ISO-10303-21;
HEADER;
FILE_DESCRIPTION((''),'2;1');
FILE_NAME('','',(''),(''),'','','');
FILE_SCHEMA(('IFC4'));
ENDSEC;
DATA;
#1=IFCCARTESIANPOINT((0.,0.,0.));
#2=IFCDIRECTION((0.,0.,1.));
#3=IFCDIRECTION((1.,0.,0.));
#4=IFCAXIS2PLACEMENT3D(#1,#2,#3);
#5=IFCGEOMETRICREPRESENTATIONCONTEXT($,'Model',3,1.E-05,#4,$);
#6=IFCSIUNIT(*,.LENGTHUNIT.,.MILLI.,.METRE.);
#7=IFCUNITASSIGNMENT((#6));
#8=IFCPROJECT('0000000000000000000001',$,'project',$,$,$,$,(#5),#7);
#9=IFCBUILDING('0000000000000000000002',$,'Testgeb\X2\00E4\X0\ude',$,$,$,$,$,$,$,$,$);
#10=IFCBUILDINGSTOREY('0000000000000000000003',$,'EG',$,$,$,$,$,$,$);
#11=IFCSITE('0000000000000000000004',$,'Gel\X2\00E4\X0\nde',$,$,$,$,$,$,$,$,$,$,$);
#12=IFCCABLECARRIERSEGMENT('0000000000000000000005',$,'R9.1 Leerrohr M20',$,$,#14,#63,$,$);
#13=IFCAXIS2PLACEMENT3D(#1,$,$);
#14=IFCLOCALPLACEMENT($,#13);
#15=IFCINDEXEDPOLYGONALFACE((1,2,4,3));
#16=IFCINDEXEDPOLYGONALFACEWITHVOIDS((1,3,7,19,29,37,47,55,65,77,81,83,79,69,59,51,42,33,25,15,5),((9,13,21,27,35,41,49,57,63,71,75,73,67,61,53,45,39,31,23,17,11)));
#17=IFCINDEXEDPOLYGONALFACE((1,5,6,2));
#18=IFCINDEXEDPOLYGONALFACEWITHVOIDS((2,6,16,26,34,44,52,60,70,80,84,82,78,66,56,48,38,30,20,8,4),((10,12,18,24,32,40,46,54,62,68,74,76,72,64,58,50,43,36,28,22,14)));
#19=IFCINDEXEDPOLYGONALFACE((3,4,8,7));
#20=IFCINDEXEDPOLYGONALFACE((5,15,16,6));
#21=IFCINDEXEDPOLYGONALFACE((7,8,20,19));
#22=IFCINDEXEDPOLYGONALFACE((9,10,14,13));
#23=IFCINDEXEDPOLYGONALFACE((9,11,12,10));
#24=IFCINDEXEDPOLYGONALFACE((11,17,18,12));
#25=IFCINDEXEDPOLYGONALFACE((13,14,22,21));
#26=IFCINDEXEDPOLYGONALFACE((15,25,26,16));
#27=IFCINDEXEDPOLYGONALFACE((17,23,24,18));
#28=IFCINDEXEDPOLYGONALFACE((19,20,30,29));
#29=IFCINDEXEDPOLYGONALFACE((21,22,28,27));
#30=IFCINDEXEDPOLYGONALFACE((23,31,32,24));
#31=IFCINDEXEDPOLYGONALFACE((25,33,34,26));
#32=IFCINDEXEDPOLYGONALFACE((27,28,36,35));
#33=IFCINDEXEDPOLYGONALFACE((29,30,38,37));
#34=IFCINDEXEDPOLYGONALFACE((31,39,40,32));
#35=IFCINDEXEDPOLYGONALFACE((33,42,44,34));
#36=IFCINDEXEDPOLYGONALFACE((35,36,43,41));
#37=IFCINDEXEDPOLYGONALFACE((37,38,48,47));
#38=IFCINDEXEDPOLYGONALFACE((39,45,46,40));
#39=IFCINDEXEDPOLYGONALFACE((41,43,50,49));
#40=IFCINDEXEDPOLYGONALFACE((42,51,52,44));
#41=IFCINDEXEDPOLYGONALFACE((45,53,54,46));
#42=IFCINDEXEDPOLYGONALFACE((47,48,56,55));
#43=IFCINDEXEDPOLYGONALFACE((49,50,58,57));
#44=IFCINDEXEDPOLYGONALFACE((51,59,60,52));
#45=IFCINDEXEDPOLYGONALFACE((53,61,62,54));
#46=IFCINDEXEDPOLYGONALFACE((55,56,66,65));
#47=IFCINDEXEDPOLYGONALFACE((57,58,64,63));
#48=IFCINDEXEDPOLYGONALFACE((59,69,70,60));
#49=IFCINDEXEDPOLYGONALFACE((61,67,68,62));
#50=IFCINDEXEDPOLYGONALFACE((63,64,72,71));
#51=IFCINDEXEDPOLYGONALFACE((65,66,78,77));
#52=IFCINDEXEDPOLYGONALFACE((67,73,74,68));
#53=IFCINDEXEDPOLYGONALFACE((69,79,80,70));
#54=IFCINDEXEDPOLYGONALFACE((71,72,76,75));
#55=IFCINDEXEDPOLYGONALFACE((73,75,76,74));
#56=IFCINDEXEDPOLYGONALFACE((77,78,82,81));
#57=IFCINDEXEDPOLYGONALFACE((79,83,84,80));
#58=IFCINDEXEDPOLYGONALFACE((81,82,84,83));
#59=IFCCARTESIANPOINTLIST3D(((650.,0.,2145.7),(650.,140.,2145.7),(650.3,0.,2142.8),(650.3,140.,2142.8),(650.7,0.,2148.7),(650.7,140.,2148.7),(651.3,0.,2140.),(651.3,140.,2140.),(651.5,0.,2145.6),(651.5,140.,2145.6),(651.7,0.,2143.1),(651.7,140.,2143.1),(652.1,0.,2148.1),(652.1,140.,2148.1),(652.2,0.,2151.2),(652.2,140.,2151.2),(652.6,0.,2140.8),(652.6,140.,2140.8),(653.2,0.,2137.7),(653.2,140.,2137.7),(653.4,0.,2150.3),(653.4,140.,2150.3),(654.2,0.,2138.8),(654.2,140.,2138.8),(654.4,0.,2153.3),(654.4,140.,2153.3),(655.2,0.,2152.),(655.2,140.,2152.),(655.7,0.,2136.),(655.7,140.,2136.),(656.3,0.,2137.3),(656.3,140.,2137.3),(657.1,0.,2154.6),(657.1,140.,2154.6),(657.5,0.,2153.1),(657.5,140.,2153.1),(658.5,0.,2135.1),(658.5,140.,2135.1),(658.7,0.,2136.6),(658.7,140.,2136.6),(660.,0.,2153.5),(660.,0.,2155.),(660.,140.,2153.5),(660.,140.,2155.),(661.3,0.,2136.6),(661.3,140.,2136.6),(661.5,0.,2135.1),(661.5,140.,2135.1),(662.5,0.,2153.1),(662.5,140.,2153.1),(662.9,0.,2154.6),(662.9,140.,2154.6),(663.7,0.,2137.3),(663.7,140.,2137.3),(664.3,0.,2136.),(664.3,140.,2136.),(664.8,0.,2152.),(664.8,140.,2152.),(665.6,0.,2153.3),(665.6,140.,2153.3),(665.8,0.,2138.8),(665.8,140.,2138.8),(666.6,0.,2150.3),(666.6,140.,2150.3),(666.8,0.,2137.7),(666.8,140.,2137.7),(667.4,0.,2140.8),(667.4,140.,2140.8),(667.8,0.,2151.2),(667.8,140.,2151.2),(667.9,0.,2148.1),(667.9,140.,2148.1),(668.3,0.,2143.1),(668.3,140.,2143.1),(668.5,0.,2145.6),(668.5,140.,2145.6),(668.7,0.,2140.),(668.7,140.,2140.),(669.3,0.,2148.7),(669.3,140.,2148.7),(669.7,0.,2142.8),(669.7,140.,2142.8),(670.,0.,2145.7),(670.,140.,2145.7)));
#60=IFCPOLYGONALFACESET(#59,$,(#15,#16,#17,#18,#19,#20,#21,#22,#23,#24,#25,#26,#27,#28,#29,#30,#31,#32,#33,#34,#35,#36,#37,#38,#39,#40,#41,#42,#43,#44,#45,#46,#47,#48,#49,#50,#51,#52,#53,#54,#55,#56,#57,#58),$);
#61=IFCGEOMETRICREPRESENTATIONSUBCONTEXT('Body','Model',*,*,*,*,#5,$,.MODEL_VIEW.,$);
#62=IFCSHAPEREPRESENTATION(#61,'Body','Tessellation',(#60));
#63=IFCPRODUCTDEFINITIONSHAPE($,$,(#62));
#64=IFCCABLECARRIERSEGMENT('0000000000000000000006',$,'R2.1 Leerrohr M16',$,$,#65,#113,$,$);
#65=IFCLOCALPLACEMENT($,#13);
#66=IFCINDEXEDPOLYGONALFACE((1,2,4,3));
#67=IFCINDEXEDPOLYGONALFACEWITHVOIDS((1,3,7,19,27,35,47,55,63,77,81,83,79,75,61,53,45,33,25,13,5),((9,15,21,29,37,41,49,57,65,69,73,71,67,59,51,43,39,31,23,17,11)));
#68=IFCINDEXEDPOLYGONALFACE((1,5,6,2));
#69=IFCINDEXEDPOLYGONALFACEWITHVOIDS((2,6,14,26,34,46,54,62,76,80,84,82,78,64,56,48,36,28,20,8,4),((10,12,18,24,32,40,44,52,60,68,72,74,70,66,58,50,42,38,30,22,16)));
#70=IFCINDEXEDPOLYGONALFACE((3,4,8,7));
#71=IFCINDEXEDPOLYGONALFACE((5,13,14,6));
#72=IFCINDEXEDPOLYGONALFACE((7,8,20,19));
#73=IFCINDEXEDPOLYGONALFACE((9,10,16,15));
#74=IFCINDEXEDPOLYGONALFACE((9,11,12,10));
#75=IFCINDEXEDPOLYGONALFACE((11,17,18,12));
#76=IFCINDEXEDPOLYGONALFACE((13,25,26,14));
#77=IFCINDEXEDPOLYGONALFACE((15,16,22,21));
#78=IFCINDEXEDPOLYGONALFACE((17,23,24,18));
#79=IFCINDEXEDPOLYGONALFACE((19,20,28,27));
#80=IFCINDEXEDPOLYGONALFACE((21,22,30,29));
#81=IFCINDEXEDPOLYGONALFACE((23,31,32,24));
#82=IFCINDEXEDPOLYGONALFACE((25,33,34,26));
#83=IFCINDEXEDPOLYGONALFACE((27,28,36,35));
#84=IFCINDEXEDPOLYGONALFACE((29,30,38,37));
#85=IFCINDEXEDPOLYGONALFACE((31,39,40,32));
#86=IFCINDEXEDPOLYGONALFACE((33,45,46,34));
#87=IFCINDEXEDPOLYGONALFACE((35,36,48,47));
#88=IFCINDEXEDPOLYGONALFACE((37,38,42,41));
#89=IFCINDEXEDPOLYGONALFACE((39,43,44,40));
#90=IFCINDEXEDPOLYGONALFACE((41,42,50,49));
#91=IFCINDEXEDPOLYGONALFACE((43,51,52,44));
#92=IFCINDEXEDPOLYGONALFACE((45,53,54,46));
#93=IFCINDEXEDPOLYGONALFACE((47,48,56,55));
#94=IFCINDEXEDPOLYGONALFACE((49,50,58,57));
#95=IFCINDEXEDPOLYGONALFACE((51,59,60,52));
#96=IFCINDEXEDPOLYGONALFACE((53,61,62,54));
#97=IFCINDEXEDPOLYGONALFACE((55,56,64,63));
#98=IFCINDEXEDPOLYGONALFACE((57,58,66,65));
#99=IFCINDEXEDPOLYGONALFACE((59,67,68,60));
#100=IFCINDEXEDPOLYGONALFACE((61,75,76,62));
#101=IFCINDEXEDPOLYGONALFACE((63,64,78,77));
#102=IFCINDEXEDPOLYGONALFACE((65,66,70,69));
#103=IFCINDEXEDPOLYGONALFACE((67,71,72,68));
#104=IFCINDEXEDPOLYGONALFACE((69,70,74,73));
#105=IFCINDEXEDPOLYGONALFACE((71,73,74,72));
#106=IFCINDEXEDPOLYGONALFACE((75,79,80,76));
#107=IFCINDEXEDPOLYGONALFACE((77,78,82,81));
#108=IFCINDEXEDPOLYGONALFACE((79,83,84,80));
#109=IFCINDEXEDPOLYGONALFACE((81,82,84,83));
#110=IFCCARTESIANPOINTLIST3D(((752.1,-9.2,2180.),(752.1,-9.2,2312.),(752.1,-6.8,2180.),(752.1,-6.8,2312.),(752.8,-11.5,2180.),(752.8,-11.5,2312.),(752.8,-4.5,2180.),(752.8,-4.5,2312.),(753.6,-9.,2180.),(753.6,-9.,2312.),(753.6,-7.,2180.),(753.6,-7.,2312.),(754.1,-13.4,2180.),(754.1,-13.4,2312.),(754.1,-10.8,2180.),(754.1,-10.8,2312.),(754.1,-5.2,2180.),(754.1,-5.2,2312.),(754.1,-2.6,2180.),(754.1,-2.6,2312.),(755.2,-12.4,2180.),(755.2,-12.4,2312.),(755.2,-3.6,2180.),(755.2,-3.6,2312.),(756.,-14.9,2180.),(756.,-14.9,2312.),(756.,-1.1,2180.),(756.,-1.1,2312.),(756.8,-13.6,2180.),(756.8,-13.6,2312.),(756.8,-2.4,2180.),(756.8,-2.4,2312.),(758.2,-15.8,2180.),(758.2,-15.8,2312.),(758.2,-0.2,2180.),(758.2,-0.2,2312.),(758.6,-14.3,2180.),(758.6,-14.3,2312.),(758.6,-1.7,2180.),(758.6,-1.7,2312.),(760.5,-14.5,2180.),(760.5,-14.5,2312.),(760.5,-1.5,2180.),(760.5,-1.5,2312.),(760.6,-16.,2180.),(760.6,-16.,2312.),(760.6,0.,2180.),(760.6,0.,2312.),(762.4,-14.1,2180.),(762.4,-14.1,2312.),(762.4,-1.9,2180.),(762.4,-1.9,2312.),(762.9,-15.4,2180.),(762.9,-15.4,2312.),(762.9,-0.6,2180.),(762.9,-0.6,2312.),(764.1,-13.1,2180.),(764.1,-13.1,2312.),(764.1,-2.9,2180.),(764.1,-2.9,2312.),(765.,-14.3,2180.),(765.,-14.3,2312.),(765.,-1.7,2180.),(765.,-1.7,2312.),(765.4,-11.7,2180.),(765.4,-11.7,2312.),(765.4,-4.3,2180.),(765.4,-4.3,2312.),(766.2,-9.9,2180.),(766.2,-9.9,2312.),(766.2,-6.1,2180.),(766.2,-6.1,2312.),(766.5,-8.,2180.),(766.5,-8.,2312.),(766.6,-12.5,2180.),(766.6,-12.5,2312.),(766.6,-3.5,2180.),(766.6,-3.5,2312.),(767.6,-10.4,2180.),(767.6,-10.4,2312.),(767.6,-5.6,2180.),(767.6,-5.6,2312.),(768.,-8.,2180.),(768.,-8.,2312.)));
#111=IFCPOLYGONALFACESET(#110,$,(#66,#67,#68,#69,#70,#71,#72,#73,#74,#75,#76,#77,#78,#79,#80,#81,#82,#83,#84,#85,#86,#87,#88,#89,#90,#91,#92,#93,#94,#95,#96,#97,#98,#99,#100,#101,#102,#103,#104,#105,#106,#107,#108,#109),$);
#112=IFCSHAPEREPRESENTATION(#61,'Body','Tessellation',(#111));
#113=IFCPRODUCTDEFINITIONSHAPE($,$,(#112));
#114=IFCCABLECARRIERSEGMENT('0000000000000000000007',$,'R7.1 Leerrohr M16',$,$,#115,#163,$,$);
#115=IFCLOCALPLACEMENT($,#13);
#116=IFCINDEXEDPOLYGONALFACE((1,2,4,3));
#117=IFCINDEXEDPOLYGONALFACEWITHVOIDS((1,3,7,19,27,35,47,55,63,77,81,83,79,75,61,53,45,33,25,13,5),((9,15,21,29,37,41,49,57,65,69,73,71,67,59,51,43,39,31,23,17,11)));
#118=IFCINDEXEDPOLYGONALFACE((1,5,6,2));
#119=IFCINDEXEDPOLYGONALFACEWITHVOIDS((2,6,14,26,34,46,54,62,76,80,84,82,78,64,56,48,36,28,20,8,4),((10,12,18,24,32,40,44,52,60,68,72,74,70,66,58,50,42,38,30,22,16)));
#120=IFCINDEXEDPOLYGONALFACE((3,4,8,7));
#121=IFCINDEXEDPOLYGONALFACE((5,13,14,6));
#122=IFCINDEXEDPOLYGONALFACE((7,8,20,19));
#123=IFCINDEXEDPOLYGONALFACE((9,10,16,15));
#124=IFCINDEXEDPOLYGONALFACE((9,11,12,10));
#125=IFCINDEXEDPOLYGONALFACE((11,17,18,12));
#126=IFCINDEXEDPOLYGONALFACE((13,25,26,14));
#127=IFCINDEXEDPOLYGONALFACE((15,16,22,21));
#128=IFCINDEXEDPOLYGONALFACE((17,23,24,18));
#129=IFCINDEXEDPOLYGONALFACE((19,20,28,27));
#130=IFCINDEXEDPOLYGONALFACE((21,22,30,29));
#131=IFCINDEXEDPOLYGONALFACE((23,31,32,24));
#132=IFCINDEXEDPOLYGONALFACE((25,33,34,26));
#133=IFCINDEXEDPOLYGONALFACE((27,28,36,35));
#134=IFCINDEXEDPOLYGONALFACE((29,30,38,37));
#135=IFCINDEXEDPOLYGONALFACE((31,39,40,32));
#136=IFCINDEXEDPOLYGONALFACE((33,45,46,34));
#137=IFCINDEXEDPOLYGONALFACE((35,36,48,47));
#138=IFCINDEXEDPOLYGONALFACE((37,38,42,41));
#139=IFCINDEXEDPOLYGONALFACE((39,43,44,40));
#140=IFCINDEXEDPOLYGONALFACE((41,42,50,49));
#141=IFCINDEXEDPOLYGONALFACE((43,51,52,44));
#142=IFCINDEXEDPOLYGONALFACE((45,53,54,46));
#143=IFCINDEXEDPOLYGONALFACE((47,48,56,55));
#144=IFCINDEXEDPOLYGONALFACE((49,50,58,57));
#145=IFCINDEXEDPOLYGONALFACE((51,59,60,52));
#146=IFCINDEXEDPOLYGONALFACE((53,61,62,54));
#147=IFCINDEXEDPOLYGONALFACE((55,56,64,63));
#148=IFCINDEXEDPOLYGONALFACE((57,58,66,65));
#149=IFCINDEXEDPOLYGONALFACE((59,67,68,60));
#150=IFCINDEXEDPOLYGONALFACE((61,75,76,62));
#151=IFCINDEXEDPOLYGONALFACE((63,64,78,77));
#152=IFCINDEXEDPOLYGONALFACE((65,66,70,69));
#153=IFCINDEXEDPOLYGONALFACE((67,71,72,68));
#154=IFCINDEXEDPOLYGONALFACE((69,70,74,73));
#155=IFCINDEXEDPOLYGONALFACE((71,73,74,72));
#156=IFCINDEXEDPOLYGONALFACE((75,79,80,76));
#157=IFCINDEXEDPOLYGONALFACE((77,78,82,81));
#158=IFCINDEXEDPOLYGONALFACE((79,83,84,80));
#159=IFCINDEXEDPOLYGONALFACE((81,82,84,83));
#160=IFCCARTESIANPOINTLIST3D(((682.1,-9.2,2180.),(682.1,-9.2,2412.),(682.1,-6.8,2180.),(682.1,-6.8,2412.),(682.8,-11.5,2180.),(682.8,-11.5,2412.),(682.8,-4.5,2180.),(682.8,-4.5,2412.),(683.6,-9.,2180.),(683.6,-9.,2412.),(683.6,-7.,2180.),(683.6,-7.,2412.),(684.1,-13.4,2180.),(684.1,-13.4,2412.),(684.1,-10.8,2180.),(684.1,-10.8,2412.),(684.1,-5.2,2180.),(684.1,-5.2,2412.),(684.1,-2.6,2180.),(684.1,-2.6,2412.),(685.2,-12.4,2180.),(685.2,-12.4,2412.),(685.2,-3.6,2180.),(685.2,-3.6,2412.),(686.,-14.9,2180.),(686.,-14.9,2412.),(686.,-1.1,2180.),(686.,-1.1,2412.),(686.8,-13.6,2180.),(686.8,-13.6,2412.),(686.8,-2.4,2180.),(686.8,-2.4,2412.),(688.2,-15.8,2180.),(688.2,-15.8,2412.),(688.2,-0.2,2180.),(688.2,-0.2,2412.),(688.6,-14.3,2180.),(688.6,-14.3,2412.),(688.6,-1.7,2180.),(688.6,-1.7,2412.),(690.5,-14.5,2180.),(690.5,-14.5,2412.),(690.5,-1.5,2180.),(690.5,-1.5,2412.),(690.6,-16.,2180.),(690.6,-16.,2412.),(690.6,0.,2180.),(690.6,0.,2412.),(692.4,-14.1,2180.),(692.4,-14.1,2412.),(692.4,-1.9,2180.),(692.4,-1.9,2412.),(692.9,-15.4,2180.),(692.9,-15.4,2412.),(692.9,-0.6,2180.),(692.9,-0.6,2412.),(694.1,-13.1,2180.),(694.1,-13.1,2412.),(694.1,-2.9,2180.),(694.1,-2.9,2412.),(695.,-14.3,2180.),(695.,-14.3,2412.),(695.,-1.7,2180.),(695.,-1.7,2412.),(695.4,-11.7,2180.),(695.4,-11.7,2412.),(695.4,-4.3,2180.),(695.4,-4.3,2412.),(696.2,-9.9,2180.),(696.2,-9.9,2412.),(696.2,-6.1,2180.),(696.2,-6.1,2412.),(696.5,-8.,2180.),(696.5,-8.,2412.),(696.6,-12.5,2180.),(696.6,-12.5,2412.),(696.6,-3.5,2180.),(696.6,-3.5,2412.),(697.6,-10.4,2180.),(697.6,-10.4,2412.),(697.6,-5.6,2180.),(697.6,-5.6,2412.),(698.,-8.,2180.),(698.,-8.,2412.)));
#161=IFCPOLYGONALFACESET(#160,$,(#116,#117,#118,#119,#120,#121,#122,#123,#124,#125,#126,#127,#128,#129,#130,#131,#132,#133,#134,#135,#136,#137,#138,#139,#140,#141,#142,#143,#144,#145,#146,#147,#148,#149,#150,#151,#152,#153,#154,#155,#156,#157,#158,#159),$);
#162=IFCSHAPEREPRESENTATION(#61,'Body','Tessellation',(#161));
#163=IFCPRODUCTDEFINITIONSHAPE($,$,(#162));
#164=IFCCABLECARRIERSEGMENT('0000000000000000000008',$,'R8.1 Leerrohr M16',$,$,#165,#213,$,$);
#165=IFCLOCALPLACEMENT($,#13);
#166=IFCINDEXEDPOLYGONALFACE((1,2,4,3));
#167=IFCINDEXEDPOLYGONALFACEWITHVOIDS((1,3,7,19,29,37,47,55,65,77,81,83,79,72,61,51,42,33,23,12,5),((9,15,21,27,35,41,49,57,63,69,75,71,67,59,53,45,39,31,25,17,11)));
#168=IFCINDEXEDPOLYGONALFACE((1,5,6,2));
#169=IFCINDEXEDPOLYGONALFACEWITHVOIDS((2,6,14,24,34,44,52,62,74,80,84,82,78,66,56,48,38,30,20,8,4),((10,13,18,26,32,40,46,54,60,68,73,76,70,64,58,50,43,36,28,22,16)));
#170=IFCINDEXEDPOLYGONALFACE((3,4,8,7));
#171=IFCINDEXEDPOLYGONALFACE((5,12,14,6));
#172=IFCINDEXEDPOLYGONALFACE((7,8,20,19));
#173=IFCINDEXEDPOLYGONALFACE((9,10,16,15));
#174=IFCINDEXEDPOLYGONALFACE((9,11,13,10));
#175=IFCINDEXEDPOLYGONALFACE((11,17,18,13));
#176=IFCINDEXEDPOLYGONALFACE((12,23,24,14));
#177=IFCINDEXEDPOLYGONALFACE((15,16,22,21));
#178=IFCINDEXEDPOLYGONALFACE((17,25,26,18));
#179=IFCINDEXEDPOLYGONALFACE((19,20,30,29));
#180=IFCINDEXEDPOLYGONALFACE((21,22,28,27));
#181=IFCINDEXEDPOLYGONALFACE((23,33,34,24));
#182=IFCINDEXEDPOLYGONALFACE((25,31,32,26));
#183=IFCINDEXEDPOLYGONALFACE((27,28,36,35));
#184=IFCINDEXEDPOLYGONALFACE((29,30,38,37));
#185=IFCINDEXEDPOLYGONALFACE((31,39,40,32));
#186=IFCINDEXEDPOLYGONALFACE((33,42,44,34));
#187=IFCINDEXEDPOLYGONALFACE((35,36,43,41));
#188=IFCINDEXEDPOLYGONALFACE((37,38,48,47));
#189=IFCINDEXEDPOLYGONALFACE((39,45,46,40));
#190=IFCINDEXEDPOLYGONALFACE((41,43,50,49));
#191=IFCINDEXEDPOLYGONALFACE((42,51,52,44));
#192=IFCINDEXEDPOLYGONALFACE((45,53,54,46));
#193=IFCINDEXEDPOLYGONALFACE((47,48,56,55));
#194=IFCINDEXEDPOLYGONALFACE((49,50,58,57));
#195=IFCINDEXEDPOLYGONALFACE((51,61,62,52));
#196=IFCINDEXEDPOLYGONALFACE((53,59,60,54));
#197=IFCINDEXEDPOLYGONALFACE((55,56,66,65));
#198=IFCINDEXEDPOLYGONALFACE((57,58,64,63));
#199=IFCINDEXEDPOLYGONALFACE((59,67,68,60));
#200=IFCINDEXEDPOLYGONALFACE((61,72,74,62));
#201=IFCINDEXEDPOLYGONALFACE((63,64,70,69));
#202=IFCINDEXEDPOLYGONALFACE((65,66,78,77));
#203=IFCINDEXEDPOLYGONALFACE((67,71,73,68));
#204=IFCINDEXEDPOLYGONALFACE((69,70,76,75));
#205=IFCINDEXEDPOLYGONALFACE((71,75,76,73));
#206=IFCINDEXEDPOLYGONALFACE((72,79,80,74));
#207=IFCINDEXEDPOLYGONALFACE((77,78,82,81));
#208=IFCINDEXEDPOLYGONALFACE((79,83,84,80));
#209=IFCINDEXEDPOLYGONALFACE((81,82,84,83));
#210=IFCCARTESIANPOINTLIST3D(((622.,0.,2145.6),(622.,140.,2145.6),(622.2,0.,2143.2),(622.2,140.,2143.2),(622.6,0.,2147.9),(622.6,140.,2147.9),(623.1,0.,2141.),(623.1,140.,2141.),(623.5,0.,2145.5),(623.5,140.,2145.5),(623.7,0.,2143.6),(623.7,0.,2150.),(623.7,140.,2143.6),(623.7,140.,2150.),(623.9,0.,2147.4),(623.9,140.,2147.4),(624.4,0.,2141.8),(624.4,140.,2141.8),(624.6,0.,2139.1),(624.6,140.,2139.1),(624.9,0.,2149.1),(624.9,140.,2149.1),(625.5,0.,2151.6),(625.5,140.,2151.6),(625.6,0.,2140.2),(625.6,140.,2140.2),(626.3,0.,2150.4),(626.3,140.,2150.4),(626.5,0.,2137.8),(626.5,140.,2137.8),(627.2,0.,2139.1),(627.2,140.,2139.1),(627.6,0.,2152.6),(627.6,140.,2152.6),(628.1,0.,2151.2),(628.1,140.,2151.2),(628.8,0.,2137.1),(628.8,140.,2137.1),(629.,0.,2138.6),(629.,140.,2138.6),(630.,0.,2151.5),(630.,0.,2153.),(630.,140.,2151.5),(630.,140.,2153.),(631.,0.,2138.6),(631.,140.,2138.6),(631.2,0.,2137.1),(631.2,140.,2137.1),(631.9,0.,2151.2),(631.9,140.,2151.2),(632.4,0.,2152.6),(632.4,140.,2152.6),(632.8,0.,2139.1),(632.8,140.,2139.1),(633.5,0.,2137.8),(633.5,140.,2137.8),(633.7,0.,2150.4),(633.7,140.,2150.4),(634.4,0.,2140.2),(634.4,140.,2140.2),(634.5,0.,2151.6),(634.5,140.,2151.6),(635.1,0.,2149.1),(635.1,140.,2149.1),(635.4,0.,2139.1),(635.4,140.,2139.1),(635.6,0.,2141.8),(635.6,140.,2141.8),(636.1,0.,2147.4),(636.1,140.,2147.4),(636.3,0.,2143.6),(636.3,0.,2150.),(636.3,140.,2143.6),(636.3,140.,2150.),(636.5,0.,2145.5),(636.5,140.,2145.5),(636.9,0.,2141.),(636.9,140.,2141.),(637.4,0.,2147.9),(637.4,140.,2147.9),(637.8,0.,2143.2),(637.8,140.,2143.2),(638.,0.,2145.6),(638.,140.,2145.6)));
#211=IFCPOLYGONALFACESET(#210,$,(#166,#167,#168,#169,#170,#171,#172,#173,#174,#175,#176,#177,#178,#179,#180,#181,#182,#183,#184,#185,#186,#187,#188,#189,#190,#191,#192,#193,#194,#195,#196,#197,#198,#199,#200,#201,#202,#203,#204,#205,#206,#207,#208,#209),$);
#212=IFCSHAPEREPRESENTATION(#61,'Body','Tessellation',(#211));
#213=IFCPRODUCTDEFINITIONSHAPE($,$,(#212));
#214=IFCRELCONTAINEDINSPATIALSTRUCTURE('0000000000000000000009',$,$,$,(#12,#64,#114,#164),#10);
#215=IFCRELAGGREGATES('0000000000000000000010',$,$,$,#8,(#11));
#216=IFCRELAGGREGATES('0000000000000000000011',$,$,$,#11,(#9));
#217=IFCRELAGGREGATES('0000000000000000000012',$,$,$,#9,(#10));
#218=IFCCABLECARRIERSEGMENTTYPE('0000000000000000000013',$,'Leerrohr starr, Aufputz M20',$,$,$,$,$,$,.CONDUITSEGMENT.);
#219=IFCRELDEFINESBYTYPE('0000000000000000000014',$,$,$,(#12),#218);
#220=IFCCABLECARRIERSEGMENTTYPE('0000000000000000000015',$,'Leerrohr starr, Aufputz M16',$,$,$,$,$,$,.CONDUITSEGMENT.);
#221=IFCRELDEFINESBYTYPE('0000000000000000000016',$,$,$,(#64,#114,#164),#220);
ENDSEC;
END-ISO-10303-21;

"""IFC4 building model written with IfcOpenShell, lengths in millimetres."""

from ifc_helpers import new_model, si_unit, frame, origin_with_axes, place, context, subcontext, project, spatial, hollow_circle, extrude, type_object, element, save


model = new_model("IFC4")

# Units and contexts
model_context = context("Model", 3, precision=1e-05, world=origin_with_axes())
body_context = subcontext(model_context, "Body", "Model", "MODEL_VIEW")
ifc_project = project(units=[si_unit("LENGTHUNIT", "METRE", prefix="MILLI")], contexts=[model_context])

# Site, building, storey
site = spatial("IfcSite", under=ifc_project, Name="Gelände")
building = spatial("IfcBuilding", under=site, Name="Testgebäude")
storey = spatial("IfcBuildingStorey", under=building, Name="EG")

# Cable carrier segment
cable_carrier_segment_type_1 = type_object("IfcCableCarrierSegmentType", Name="Leerrohr starr, Aufputz M20", PredefinedType="CONDUITSEGMENT")
cable_carrier_segment_1_placement = place(None, frame((660.0, 0.0, 2145.0), z_axis=(0.0, 1.0, 0.0), x_axis=(0.0, 0.0, 1.0)))
element("IfcCableCarrierSegment", 1, at=cable_carrier_segment_1_placement, inside=storey, type_object=cable_carrier_segment_type_1, Name="R9.1 Leerrohr M20", context=body_context, shape_type="SweptSolid", body=[
    extrude(hollow_circle(Radius=10.0, WallThickness=1.5), None, (0.0, 0.0, 1.0), 140.0),
])

# Cable carrier segments
cable_carrier_segment_type_2 = type_object("IfcCableCarrierSegmentType", Name="Leerrohr starr, Aufputz M16", PredefinedType="CONDUITSEGMENT")
cable_carrier_segment_2_placement = place(None, frame((760.0, -8.0, 2180.0), z_axis=(0.0, 0.0, 1.0), x_axis=(1.0, 0.0, 0.0)))
element("IfcCableCarrierSegment", 2, at=cable_carrier_segment_2_placement, inside=storey, type_object=cable_carrier_segment_type_2, Name="R2.1 Leerrohr M16", context=body_context, shape_type="SweptSolid", body=[
    extrude(hollow_circle(Radius=8.0, WallThickness=1.5), None, (0.0, 0.0, 1.0), 132.0),
])
cable_carrier_segment_3_placement = place(None, frame((690.0, -8.0, 2180.0), z_axis=(0.0, 0.0, 1.0), x_axis=(1.0, 0.0, 0.0)))
element("IfcCableCarrierSegment", 3, at=cable_carrier_segment_3_placement, inside=storey, type_object=cable_carrier_segment_type_2, Name="R7.1 Leerrohr M16", context=body_context, shape_type="SweptSolid", body=[
    extrude(hollow_circle(Radius=8.0, WallThickness=1.5), None, (0.0, 0.0, 1.0), 232.0),
])
cable_carrier_segment_4_placement = place(None, frame((630.0, 0.0, 2145.0), z_axis=(0.0, 1.0, 0.0), x_axis=(0.0, 0.0, 1.0)))
element("IfcCableCarrierSegment", 4, at=cable_carrier_segment_4_placement, inside=storey, type_object=cable_carrier_segment_type_2, Name="R8.1 Leerrohr M16", context=body_context, shape_type="SweptSolid", body=[
    extrude(hollow_circle(Radius=8.0, WallThickness=1.5), None, (0.0, 0.0, 1.0), 140.0),
])

save(model, "model.ifc")
